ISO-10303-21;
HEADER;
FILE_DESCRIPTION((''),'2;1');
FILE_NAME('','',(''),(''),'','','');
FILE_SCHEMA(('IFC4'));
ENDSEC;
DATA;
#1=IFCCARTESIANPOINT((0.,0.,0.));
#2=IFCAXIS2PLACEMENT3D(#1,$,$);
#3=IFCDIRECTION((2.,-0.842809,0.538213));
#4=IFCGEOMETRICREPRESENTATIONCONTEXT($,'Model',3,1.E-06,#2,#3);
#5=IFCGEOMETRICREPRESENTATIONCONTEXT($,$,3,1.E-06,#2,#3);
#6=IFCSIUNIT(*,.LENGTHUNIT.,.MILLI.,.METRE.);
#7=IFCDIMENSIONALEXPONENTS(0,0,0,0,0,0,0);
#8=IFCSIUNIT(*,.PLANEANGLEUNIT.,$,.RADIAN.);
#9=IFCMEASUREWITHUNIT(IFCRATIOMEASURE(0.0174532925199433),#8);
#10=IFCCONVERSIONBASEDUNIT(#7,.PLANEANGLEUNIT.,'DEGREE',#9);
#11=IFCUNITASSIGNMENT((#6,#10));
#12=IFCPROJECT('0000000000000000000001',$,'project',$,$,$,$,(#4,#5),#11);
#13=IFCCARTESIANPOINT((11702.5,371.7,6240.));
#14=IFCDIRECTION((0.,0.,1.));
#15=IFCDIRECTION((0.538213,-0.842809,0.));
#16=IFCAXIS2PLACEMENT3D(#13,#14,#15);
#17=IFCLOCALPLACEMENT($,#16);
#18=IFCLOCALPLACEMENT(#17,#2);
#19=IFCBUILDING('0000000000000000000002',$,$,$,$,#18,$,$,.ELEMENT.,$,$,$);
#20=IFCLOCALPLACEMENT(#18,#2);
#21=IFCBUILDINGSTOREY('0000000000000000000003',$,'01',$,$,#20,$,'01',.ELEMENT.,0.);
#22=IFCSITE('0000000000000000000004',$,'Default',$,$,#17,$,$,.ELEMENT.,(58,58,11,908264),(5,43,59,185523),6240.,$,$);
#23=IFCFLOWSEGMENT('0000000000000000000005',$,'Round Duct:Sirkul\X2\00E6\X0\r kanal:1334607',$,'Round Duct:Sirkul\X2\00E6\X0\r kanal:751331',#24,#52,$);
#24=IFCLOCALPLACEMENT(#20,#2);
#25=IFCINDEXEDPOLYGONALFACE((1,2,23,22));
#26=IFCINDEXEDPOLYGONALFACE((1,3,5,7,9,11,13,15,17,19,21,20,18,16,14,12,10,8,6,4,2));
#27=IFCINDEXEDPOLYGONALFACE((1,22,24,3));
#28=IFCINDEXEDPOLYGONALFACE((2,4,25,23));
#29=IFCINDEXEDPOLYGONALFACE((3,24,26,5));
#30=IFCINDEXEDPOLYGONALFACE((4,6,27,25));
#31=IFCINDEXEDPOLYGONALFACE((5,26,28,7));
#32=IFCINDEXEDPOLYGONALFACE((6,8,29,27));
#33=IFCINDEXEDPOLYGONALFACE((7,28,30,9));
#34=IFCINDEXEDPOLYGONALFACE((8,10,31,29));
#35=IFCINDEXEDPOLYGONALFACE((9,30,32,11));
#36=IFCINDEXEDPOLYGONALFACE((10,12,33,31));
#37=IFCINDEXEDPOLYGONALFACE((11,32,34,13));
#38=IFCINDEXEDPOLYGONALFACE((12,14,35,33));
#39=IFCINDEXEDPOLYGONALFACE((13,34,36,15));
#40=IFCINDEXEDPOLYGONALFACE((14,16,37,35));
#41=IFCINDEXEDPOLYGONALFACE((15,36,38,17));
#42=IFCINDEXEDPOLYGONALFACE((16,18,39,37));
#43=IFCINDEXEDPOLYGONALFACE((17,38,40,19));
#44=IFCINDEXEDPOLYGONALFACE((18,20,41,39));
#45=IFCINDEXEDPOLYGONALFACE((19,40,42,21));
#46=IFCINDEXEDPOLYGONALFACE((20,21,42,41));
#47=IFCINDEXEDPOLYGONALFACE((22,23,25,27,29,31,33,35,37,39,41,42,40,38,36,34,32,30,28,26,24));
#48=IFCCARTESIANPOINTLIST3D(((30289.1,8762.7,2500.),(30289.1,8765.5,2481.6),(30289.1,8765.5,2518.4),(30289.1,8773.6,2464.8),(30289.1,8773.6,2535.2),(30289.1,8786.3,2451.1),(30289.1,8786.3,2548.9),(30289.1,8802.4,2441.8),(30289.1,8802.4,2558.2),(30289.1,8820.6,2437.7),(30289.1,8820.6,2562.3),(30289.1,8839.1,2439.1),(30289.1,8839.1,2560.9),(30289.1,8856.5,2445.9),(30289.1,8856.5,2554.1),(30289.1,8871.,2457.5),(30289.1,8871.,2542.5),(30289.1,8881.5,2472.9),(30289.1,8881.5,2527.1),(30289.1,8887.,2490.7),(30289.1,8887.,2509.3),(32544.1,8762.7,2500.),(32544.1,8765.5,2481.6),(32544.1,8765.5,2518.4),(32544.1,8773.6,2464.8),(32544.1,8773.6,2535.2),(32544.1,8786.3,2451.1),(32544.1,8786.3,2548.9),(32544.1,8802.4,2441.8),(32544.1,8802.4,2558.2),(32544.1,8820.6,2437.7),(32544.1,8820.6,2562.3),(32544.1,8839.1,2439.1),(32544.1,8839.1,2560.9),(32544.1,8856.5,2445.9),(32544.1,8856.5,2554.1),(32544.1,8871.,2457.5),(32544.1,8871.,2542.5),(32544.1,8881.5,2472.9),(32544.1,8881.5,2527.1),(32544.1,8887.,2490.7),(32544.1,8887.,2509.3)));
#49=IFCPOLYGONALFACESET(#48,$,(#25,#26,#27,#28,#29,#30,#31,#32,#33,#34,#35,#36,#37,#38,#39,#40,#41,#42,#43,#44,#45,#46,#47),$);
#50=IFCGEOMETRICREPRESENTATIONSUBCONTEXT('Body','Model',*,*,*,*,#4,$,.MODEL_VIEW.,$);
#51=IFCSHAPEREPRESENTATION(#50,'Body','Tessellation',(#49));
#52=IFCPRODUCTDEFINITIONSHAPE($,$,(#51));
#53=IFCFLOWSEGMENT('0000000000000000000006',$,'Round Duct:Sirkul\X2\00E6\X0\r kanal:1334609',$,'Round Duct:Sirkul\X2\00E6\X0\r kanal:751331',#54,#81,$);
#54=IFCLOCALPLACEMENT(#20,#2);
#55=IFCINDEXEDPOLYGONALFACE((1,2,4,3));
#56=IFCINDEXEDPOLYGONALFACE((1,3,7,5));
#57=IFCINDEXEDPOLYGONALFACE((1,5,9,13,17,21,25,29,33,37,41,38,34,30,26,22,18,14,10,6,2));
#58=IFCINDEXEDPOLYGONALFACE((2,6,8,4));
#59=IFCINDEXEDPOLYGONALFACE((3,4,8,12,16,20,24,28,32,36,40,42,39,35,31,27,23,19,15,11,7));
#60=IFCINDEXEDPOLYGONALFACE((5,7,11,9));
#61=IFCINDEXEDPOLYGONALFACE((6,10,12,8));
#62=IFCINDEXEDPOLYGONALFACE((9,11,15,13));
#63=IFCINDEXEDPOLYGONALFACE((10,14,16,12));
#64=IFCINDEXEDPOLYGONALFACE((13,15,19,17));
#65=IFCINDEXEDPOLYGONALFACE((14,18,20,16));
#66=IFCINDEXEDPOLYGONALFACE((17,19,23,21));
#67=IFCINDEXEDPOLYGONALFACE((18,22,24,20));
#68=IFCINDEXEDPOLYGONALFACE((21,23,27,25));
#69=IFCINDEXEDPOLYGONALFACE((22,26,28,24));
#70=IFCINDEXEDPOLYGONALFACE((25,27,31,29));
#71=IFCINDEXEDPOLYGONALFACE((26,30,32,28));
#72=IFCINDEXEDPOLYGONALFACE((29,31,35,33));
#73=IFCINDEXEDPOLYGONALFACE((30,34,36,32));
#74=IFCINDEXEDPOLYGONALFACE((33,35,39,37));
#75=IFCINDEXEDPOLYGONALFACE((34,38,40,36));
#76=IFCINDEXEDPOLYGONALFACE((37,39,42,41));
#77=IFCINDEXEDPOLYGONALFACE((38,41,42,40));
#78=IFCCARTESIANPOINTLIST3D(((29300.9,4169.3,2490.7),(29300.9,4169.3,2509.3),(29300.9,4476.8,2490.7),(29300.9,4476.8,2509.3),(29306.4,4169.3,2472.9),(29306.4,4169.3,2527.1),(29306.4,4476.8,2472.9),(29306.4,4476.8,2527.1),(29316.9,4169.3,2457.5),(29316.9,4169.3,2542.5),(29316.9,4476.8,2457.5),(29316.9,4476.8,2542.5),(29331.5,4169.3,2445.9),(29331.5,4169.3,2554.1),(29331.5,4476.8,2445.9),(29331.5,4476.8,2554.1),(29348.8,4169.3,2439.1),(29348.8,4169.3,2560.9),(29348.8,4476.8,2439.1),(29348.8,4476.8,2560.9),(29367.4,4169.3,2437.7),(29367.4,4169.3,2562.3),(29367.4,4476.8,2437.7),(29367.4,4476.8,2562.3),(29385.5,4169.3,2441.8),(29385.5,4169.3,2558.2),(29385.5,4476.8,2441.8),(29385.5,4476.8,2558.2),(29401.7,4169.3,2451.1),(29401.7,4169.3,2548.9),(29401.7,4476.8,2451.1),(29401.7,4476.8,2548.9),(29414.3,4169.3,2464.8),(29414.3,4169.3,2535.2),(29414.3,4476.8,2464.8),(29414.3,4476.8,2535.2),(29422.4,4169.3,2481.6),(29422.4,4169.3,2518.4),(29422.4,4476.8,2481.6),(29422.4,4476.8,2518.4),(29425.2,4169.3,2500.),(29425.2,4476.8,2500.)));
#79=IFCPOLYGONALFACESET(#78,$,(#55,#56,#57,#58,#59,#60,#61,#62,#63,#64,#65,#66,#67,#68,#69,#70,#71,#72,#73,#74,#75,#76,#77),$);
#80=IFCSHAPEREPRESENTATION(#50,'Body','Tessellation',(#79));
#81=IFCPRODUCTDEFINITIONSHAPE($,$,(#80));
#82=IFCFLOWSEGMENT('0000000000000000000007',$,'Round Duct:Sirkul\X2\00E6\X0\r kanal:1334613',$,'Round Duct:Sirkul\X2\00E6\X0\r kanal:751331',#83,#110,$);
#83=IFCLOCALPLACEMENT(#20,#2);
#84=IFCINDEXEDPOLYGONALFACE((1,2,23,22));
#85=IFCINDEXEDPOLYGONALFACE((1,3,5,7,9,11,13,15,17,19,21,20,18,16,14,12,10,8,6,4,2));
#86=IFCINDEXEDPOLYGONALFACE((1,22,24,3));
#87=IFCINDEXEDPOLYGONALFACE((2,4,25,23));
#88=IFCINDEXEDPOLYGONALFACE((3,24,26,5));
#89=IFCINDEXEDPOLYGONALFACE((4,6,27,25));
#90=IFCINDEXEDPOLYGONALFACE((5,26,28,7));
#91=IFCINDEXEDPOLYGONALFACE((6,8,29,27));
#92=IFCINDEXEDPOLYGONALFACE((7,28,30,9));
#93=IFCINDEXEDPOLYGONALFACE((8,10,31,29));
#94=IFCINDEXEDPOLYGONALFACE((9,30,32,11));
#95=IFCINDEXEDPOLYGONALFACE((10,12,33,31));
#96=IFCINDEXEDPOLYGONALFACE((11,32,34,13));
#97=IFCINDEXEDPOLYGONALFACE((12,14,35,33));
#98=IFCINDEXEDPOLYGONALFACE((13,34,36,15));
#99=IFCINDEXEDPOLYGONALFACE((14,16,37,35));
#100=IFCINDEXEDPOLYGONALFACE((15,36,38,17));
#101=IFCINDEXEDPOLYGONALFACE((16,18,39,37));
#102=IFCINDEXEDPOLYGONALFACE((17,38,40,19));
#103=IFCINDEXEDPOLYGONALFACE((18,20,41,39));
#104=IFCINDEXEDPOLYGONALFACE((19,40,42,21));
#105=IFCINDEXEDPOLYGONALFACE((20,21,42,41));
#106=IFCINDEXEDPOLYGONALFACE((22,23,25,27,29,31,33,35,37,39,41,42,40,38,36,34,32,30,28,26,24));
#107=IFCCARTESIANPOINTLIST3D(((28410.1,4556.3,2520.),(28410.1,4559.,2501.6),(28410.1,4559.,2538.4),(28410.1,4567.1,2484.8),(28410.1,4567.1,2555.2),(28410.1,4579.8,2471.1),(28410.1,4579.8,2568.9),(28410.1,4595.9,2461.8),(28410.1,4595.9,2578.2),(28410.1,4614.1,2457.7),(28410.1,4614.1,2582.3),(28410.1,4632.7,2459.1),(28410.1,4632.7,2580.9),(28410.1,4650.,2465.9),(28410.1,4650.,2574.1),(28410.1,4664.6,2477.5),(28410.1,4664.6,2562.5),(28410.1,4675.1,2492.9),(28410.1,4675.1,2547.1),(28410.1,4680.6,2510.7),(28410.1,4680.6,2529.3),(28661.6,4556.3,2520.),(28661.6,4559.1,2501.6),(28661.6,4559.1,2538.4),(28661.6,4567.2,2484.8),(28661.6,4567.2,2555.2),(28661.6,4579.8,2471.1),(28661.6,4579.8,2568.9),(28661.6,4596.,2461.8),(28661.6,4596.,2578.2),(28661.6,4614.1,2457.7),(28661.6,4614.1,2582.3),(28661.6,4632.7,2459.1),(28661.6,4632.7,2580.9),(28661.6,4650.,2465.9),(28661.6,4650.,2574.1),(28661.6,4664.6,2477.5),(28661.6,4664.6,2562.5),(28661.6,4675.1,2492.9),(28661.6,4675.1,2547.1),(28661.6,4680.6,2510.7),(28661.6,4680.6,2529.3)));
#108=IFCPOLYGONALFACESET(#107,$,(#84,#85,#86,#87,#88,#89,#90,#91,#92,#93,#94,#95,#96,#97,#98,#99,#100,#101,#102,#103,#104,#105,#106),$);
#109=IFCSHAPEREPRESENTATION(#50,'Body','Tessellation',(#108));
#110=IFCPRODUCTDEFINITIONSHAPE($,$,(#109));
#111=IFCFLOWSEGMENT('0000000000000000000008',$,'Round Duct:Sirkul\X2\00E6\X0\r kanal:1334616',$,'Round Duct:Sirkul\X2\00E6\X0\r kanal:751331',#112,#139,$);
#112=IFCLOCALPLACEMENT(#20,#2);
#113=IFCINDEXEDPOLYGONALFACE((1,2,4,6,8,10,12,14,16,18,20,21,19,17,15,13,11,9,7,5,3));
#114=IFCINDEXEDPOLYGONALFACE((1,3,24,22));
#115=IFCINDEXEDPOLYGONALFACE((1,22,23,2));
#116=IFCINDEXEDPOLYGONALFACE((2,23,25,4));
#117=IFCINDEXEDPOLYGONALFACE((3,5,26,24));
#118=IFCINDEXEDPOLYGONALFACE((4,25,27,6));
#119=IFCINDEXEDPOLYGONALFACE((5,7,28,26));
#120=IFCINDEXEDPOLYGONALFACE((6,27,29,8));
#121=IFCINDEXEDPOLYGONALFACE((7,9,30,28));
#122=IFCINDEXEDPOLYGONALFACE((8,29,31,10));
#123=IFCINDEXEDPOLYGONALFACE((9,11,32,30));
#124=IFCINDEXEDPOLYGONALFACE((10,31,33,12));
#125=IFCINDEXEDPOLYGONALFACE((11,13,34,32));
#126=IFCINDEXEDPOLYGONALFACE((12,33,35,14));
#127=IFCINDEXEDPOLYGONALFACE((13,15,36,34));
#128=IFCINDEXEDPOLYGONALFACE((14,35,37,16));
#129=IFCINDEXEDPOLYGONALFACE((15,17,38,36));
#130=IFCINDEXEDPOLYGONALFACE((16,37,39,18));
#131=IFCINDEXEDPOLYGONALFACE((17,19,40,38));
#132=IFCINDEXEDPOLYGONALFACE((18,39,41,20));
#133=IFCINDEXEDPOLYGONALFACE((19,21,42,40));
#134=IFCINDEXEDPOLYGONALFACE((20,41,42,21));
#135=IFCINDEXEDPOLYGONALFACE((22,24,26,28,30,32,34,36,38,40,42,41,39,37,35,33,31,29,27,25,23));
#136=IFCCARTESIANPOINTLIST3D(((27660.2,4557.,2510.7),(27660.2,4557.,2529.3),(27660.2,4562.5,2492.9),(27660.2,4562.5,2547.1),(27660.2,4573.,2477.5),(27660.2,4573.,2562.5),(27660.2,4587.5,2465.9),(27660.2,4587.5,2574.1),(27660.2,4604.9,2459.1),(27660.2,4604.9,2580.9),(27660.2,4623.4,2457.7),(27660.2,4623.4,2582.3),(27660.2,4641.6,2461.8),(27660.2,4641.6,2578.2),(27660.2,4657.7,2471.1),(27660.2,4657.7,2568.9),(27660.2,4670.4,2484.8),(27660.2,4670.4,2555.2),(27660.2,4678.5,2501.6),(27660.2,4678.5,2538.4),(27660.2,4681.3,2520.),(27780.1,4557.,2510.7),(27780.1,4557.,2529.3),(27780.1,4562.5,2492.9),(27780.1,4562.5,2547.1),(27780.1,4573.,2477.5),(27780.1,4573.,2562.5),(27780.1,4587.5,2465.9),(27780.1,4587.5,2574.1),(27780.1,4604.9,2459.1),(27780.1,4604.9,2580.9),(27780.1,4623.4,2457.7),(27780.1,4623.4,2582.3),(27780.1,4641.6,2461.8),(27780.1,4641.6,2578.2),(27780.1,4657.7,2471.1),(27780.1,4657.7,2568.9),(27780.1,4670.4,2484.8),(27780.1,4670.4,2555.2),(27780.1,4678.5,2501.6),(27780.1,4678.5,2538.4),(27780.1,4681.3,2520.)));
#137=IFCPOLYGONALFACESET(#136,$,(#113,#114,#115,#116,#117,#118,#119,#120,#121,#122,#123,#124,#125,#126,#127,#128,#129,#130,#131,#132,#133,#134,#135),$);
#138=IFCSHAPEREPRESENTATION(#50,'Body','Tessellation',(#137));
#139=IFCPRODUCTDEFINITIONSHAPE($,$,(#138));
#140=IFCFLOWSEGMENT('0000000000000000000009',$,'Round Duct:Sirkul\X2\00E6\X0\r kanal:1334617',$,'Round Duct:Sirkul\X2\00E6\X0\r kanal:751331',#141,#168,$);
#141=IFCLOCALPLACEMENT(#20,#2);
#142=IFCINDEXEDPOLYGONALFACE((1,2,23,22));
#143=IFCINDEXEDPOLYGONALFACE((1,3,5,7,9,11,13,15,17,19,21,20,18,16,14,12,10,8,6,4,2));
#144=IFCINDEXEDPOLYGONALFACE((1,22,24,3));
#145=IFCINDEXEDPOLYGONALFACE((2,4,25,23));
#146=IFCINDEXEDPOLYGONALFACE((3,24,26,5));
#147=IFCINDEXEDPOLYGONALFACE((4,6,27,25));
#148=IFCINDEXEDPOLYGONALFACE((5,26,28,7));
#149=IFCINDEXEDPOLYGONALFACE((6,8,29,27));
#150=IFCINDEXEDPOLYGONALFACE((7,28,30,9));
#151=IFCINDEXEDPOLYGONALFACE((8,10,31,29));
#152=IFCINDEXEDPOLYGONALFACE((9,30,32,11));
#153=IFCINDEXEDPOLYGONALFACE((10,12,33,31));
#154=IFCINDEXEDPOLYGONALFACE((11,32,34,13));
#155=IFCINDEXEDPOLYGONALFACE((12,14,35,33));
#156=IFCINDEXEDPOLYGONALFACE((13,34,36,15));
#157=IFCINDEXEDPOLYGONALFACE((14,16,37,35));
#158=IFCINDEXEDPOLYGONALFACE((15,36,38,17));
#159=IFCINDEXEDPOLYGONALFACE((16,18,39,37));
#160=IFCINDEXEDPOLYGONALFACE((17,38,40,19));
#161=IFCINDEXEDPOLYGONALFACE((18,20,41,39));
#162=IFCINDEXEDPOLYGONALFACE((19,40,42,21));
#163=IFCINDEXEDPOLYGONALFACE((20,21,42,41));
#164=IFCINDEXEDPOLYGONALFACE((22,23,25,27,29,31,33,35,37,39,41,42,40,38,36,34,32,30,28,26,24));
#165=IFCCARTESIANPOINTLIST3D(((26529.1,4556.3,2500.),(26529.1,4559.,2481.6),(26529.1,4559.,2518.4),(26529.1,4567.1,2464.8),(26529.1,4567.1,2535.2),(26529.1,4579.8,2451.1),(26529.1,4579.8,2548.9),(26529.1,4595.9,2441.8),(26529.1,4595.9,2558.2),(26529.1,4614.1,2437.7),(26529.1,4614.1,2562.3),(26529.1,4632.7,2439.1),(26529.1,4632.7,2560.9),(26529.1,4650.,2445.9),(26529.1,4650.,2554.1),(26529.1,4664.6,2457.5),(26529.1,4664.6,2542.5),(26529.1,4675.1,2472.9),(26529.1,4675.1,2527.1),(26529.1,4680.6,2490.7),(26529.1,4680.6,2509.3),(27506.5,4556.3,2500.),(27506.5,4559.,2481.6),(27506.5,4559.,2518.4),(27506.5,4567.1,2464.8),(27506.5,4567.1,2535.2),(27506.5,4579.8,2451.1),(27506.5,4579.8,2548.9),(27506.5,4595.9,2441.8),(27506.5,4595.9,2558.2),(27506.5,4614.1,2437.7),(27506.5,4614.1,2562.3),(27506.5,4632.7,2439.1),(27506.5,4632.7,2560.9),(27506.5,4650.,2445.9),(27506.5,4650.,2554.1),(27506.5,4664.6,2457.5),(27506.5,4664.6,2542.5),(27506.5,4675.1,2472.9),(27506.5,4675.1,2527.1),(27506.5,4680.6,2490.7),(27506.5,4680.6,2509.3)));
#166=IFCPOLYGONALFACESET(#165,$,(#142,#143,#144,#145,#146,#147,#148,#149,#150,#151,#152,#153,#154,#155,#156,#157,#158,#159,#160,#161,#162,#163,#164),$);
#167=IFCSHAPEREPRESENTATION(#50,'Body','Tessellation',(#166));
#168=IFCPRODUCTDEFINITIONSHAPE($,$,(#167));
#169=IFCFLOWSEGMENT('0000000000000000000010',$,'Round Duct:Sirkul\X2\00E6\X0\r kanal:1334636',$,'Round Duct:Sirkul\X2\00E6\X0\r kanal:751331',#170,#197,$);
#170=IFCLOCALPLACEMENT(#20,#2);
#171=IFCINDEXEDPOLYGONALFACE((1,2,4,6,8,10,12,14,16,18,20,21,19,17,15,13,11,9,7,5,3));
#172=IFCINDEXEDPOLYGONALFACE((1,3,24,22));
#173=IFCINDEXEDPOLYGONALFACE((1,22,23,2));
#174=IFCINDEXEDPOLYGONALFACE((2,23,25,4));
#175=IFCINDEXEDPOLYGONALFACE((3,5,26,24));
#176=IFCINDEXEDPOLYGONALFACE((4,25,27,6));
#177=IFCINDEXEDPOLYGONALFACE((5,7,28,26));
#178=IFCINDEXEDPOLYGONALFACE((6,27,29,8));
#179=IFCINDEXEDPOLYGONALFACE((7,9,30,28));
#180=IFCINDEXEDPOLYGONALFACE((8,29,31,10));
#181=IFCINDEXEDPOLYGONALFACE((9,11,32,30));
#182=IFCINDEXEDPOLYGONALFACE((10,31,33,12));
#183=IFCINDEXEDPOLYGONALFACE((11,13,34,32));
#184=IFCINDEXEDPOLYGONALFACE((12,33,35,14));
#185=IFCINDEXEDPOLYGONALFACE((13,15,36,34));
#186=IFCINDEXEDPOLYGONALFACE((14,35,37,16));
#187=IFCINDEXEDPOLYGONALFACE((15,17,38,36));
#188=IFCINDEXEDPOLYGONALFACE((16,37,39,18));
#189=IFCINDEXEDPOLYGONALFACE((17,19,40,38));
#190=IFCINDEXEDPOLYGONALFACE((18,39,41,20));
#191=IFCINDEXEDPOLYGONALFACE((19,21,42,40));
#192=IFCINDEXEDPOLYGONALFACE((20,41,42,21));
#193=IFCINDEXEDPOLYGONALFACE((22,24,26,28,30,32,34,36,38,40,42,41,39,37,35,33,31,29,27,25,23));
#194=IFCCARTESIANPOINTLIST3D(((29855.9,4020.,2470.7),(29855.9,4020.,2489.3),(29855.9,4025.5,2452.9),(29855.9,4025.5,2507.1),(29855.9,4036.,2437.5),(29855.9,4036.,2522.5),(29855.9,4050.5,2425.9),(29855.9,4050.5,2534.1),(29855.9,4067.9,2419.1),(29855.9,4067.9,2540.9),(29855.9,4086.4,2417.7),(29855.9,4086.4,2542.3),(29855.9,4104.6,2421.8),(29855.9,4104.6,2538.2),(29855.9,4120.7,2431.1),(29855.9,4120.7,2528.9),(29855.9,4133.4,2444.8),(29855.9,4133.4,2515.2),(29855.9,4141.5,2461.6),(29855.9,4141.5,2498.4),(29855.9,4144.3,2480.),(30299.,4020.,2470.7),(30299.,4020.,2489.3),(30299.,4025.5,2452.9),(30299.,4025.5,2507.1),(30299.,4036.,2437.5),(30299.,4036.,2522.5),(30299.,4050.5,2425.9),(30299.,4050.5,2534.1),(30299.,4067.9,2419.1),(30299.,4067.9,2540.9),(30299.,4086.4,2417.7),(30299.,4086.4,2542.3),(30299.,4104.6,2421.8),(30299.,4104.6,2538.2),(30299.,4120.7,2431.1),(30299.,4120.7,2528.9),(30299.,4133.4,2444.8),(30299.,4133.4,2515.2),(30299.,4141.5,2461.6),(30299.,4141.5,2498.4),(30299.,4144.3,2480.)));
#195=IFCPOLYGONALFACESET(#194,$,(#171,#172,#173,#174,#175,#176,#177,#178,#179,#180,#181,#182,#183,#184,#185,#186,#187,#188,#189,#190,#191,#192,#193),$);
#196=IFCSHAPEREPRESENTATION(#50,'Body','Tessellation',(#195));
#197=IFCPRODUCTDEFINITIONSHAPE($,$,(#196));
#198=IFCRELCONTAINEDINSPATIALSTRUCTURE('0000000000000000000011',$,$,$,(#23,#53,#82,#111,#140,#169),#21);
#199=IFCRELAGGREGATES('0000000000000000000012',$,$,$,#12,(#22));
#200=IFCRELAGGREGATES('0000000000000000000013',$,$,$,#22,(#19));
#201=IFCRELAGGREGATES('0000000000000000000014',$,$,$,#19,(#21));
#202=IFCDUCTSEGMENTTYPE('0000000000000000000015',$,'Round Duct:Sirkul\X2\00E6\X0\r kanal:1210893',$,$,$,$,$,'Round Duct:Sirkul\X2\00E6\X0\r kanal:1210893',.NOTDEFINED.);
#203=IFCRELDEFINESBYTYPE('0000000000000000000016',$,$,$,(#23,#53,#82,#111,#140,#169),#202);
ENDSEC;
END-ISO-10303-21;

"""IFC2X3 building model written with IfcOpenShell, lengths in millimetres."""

from ifc_helpers import new_model, entity, si_unit, converted_unit, direction, frame, frame_2d, origin, origin_2d_with_axis, place, context, subcontext, project, spatial, circle, extrude, type_object, element, save


model = new_model("IFC2X3")

# Units and contexts
model_context = context("Model", 3, precision=1e-06, world=origin(), true_north=direction((2.0, -0.842809, 0.538213)))
context_of_model = context(None, 3, precision=1e-06, world=origin(), true_north=direction((2.0, -0.842809, 0.538213)))
body_context = subcontext(model_context, "Body", "Model", "MODEL_VIEW")
ifc_project = project(units=[si_unit("LENGTHUNIT", "METRE", prefix="MILLI"), converted_unit("PLANEANGLEUNIT", "DEGREE", entity("IfcRatioMeasure", 0.0174532925199433), si_unit("PLANEANGLEUNIT", "RADIAN"), dimensions=[0, 0, 0, 0, 0, 0, 0])], contexts=[model_context, context_of_model])

# Site, building, storey
site_placement = place(None, frame((11702.5, 371.7, 6240.0), z_axis=(0.0, 0.0, 1.0), x_axis=(0.538213, -0.842809, 0.0)))
site = spatial("IfcSite", under=ifc_project, at=site_placement, Name="Default", CompositionType="ELEMENT", RefLatitude=(58, 58, 11, 908264), RefLongitude=(5, 43, 59, 185523), RefElevation=6240.0)
building_placement = place(site_placement, origin())
building = spatial("IfcBuilding", under=site, at=building_placement, CompositionType="ELEMENT")
storey_placement = place(building_placement, origin())
storey = spatial("IfcBuildingStorey", under=building, at=storey_placement, Name="01", LongName="01", CompositionType="ELEMENT", Elevation=0.0)

# Flow segments
duct_segment_type = type_object("IfcDuctSegmentType", Name="Round Duct:Sirkulær kanal:1210893", ElementType="Round Duct:Sirkulær kanal:1210893", PredefinedType="NOTDEFINED")
flow_segment_1_placement = place(storey_placement, origin())
element("IfcFlowSegment", 1, at=flow_segment_1_placement, inside=storey, type_object=duct_segment_type, Name="Round Duct:Sirkulær kanal:1334607", ObjectType="Round Duct:Sirkulær kanal:751331", context=body_context, shape_type="SweptSolid", body=[
    extrude(circle(Radius=62.5, at=origin_2d_with_axis()), frame((30289.1, 8825.2, 2500.0), z_axis=(1.0, 0.0, 0.0), x_axis=(0.0, -1.0, 0.0)), (0.0, 0.0, 1.0), 2255.0),
])
flow_segment_2_placement = place(storey_placement, origin())
element("IfcFlowSegment", 2, at=flow_segment_2_placement, inside=storey, type_object=duct_segment_type, Name="Round Duct:Sirkulær kanal:1334609", ObjectType="Round Duct:Sirkulær kanal:751331", context=body_context, shape_type="SweptSolid", body=[
    extrude(circle(Radius=62.5, at=origin_2d_with_axis()), frame((29362.7, 4169.3, 2500.0), z_axis=(0.0, 1.0, 0.0), x_axis=(1.0, 0.0, 0.0)), (0.0, 0.0, 1.0), 307.5),
])
flow_segment_3_placement = place(storey_placement, origin())
element("IfcFlowSegment", 3, at=flow_segment_3_placement, inside=storey, type_object=duct_segment_type, Name="Round Duct:Sirkulær kanal:1334613", ObjectType="Round Duct:Sirkulær kanal:751331", context=body_context, shape_type="SweptSolid", body=[
    extrude(circle(Radius=62.5, at=frame_2d((0.0, 0.0), x_axis=(1.0, 0.0))), frame((28410.1, 4618.8, 2520.0), z_axis=(1.0, 0.000104, 0.0), x_axis=(0.000104, -1.0, 0.0)), (0.0, 0.0, 1.0), 251.5),
])
flow_segment_4_placement = place(storey_placement, origin())
element("IfcFlowSegment", 4, at=flow_segment_4_placement, inside=storey, type_object=duct_segment_type, Name="Round Duct:Sirkulær kanal:1334616", ObjectType="Round Duct:Sirkulær kanal:751331", context=body_context, shape_type="SweptSolid", body=[
    extrude(circle(Radius=62.5, at=frame_2d((0.0, 0.0), x_axis=(1.0, 0.0))), frame((27660.2, 4618.8, 2520.0), z_axis=(1.0, 0.0, 0.0), x_axis=(0.0, 1.0, 0.0)), (0.0, 0.0, 1.0), 119.9),
])
flow_segment_5_placement = place(storey_placement, origin())
element("IfcFlowSegment", 5, at=flow_segment_5_placement, inside=storey, type_object=duct_segment_type, Name="Round Duct:Sirkulær kanal:1334617", ObjectType="Round Duct:Sirkulær kanal:751331", context=body_context, shape_type="SweptSolid", body=[
    extrude(circle(Radius=62.5, at=origin_2d_with_axis()), frame((26529.1, 4618.8, 2500.0), z_axis=(1.0, 0.0, 0.0), x_axis=(0.0, -1.0, 0.0)), (0.0, 0.0, 1.0), 977.4),
])
flow_segment_6_placement = place(storey_placement, origin())
element("IfcFlowSegment", 6, at=flow_segment_6_placement, inside=storey, type_object=duct_segment_type, Name="Round Duct:Sirkulær kanal:1334636", ObjectType="Round Duct:Sirkulær kanal:751331", context=body_context, shape_type="SweptSolid", body=[
    extrude(circle(Radius=62.5, at=frame_2d((0.0, 0.0), x_axis=(1.0, 0.0))), frame((29855.9, 4081.8, 2480.0), z_axis=(1.0, 0.0, 0.0), x_axis=(0.0, 1.0, 0.0)), (0.0, 0.0, 1.0), 443.0),
])

save(model, "model.ifc")
